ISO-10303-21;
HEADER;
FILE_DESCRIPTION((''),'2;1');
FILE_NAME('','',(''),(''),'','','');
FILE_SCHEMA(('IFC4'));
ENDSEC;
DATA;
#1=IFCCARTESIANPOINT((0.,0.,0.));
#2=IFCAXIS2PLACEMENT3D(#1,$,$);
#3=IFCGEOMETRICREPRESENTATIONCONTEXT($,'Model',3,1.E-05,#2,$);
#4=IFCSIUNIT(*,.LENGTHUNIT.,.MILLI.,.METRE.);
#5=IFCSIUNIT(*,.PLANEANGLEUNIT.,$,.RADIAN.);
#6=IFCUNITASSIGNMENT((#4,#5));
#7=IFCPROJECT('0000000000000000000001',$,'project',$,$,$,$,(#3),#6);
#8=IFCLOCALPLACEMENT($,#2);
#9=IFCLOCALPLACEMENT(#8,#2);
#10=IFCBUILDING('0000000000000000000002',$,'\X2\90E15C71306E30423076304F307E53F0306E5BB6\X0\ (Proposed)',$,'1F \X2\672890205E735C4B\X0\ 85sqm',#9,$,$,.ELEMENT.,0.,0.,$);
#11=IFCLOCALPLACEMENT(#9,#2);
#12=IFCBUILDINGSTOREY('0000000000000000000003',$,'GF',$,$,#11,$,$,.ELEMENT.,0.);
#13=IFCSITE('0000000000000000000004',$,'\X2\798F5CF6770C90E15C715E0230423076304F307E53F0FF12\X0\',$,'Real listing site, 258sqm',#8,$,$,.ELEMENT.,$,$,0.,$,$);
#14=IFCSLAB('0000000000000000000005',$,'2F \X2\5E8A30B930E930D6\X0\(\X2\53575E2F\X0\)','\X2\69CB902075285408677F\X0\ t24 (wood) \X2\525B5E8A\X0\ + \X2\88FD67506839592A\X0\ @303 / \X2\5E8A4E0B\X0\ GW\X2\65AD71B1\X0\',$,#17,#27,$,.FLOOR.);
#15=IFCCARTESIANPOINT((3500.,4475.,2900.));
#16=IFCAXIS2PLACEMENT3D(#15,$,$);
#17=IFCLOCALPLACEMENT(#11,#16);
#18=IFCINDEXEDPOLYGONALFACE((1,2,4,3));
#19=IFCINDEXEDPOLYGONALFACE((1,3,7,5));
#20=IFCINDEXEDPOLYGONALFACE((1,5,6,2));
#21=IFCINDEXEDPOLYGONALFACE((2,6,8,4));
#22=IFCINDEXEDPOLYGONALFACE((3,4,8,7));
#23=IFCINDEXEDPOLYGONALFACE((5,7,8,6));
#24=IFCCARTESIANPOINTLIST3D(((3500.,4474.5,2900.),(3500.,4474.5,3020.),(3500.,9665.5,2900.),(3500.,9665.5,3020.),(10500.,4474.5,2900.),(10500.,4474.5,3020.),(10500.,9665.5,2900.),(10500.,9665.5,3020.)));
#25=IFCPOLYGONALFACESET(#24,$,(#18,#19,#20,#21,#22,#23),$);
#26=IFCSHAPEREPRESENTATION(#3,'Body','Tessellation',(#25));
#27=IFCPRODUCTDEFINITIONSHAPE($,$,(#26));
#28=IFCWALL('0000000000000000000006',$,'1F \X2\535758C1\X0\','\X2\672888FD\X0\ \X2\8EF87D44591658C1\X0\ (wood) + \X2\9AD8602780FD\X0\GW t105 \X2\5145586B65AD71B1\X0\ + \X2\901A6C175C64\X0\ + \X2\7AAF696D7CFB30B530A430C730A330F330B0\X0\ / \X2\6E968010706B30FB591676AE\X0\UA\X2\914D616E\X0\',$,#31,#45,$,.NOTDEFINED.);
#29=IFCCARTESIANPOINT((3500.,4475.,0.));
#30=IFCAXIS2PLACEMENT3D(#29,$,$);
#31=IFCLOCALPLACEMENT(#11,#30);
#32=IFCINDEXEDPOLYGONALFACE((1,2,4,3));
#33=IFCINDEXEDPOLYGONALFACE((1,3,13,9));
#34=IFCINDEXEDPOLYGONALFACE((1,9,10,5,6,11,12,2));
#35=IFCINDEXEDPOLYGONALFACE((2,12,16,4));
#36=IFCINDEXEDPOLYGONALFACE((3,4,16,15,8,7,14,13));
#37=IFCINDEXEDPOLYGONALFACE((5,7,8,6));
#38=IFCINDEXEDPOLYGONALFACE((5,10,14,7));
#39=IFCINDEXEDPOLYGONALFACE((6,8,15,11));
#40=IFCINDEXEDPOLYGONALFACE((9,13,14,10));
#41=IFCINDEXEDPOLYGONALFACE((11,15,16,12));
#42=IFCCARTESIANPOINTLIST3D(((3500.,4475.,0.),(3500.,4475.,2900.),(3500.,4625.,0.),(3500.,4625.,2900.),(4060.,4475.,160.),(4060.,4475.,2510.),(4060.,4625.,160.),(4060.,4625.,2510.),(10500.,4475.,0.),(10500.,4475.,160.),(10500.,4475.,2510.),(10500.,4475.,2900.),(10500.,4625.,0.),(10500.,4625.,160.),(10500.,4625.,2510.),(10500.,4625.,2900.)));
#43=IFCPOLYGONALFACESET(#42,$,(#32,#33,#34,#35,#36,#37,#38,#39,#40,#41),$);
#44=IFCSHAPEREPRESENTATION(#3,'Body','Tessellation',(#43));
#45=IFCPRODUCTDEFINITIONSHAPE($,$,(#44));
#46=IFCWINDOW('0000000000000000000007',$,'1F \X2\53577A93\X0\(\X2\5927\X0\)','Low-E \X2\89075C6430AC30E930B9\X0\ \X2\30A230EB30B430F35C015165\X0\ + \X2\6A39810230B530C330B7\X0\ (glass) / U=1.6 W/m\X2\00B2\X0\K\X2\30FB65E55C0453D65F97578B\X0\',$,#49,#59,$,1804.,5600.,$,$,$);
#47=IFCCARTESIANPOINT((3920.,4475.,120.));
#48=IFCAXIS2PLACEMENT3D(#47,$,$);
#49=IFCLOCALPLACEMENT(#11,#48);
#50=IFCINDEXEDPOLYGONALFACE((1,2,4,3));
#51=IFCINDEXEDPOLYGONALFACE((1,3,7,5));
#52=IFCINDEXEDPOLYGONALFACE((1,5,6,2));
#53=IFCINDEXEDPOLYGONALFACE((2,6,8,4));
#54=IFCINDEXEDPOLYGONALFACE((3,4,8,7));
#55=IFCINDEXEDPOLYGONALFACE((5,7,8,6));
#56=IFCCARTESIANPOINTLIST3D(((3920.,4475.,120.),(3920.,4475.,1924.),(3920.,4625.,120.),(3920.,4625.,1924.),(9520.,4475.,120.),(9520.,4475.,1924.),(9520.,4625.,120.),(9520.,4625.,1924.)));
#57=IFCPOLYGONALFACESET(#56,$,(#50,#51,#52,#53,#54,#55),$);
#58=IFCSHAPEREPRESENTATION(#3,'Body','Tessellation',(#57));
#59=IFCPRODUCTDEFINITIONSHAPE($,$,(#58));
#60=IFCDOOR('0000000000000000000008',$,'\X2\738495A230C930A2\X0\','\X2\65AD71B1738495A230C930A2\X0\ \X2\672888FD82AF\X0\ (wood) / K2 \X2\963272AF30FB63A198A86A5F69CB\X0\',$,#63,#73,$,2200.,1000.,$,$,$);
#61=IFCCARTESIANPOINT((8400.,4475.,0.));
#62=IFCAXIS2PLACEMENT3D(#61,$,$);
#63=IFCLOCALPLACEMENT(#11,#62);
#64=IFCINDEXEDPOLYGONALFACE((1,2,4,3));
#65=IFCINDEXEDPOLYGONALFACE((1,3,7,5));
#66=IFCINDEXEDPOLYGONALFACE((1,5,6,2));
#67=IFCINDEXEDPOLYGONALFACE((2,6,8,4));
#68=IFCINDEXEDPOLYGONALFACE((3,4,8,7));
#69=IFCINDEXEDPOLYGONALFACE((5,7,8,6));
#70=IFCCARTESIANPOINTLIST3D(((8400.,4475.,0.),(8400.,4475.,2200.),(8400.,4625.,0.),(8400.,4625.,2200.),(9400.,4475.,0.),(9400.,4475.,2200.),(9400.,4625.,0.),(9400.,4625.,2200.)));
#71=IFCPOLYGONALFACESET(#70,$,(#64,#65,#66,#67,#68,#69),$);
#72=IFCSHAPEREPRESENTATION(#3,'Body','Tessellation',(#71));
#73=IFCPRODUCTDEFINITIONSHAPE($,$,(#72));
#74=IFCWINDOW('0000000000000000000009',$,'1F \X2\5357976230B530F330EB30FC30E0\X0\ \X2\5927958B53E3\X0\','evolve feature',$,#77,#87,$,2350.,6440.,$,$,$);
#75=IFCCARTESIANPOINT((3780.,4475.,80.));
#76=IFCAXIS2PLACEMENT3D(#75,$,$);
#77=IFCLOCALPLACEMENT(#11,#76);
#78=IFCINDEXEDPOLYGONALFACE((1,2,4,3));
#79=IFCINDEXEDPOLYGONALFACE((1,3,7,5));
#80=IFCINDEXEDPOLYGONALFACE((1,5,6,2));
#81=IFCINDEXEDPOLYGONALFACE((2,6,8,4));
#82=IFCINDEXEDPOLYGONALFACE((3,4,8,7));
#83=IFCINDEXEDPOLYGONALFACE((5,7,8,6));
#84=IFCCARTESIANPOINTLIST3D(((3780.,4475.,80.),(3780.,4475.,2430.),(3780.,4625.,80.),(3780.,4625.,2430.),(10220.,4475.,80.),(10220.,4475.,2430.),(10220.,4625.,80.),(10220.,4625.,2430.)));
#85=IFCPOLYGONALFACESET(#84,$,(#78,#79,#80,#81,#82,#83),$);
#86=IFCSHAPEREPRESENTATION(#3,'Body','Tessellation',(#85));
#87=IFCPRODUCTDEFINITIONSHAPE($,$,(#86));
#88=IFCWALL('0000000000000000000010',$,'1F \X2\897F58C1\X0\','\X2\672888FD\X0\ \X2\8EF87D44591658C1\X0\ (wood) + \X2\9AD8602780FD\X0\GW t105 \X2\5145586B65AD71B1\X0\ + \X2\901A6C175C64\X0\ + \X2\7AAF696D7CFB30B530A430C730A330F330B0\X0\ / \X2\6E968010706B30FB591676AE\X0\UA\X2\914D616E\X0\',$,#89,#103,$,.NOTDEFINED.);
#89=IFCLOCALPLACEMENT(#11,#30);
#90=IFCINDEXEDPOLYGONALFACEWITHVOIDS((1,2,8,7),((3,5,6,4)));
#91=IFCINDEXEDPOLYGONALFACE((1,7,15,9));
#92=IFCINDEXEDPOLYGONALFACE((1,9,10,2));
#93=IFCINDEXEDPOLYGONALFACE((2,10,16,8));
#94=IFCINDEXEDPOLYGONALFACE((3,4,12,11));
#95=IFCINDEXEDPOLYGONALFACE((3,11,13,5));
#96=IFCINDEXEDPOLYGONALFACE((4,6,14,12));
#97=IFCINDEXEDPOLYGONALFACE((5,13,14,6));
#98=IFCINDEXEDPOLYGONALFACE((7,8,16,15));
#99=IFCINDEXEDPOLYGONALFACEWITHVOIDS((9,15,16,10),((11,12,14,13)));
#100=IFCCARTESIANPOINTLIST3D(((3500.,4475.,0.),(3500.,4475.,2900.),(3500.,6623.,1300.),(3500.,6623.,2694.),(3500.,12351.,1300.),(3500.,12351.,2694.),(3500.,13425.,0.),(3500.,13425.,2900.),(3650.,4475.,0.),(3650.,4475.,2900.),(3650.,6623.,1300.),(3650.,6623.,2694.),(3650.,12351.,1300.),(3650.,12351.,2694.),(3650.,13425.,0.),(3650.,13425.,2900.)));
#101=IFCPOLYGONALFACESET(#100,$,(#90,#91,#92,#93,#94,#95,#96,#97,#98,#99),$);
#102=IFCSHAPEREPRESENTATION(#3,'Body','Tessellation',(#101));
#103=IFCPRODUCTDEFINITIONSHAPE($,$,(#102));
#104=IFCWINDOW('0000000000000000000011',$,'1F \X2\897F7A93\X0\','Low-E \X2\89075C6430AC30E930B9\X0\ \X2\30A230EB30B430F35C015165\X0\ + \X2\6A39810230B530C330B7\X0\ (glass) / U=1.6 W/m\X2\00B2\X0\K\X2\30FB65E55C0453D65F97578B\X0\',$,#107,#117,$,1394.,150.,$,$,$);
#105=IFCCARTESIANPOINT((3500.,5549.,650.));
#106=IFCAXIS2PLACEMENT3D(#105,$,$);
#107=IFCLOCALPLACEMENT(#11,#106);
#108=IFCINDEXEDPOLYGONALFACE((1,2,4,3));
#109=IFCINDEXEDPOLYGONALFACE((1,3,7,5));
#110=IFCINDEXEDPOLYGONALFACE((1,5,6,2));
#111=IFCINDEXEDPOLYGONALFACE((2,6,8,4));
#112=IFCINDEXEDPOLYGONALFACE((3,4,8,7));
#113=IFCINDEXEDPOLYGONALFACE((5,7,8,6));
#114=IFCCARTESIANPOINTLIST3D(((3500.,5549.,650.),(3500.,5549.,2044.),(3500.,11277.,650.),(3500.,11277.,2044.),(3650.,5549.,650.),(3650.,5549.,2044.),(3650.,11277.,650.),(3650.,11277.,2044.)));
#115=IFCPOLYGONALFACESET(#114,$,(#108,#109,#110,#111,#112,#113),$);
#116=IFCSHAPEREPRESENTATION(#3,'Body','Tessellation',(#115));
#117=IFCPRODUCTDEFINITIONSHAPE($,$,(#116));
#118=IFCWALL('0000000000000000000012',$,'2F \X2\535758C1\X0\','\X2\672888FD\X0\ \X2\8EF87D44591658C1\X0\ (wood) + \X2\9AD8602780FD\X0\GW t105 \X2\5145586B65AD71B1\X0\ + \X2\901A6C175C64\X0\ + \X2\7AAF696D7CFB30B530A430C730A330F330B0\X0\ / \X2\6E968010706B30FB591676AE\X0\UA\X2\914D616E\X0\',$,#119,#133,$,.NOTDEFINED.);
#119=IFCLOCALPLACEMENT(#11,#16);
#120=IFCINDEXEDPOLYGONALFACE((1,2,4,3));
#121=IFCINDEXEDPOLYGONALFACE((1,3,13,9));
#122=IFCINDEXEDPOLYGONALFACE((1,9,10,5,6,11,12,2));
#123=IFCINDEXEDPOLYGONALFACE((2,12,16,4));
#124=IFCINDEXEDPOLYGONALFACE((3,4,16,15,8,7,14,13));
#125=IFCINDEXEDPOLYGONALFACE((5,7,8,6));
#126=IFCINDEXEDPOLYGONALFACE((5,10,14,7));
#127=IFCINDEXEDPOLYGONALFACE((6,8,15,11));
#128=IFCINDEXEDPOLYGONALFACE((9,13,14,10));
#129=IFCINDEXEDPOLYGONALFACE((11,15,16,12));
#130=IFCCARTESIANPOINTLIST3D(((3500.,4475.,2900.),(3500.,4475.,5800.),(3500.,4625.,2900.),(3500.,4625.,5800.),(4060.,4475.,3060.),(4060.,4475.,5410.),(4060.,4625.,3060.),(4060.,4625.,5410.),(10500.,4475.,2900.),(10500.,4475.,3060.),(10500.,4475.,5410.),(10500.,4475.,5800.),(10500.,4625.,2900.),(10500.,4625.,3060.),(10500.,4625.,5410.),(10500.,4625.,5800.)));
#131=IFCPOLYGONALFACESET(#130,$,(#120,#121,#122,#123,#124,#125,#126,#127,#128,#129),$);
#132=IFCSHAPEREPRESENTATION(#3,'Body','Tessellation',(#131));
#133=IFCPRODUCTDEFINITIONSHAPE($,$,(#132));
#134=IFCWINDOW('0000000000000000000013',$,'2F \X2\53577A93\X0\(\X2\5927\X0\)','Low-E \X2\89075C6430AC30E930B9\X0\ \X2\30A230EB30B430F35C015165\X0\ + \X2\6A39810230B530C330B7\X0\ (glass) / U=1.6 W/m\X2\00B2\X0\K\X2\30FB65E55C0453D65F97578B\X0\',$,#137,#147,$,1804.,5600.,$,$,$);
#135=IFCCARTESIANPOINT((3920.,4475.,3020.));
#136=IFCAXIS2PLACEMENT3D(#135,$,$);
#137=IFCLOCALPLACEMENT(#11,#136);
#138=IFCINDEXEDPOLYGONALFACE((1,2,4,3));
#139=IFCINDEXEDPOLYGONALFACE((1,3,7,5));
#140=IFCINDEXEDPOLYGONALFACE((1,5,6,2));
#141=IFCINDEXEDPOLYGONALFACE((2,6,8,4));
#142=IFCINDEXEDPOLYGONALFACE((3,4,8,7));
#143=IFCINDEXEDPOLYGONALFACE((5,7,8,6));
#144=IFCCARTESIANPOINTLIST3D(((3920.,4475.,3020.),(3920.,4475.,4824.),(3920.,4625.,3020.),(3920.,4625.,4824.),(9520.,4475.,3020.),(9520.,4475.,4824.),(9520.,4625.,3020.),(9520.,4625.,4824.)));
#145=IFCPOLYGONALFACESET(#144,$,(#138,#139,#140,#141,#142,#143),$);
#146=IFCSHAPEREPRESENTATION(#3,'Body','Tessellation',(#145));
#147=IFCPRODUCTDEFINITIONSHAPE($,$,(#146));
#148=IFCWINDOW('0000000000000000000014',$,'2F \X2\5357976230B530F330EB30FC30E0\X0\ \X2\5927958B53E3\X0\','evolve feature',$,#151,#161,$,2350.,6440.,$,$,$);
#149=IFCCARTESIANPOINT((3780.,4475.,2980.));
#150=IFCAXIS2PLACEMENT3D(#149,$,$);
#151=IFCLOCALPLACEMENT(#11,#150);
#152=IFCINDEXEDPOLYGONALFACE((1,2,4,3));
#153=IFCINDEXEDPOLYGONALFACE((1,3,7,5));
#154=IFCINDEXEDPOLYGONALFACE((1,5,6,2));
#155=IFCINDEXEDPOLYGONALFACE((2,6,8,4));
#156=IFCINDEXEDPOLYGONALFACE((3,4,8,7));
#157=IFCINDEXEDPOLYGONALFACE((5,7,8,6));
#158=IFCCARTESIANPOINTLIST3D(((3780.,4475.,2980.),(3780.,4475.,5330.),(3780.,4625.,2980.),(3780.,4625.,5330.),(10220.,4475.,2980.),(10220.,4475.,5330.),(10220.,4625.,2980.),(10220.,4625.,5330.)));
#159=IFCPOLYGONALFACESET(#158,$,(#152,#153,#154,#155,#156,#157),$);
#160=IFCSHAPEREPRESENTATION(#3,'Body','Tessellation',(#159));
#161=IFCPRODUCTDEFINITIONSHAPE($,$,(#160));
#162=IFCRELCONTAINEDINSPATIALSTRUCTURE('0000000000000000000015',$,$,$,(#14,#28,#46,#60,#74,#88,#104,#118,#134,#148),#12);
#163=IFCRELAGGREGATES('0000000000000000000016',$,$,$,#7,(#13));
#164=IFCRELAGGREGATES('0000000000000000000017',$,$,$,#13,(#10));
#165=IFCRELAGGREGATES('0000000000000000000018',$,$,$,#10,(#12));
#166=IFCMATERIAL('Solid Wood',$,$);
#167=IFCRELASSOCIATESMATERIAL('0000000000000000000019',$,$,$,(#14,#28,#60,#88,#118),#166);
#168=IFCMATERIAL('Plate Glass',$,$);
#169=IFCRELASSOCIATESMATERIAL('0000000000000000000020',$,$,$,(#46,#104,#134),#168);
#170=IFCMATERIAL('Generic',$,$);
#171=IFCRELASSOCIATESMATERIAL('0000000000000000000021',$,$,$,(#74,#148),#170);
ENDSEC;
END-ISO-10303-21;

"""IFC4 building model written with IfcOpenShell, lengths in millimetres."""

from ifc_helpers import new_model, si_unit, frame, frame_2d, origin, place, context, project, spatial, rectangle, extrude, material, element, fill, save


model = new_model("IFC4")

# Units and contexts
model_context = context("Model", 3, precision=1e-05, world=origin())
ifc_project = project(units=[si_unit("LENGTHUNIT", "METRE", prefix="MILLI"), si_unit("PLANEANGLEUNIT", "RADIAN")], contexts=[model_context])

# Site, building, storey
site_placement = place(None, origin())
site = spatial("IfcSite", under=ifc_project, at=site_placement, Name="福島県郡山市あぶくま台２", ObjectType="Real listing site, 258sqm", CompositionType="ELEMENT", RefElevation=0.0)
building_placement = place(site_placement, origin())
building = spatial("IfcBuilding", under=site, at=building_placement, Name="郡山のあぶくま台の家 (Proposed)", ObjectType="1F 木造平屋 85sqm", CompositionType="ELEMENT", ElevationOfRefHeight=0.0, ElevationOfTerrain=0.0)
storey_placement = place(building_placement, origin())
storey = spatial("IfcBuildingStorey", under=building, at=storey_placement, Name="GF", CompositionType="ELEMENT", Elevation=0.0)

# Slab
ifc_material_1 = material(Name="Solid Wood")
slab_1_placement = place(storey_placement, frame((3500.0, 4475.0, 2900.0)))
element("IfcSlab", 1, at=slab_1_placement, inside=storey, material=ifc_material_1, Name="2F 床スラブ(南帯)", Description="構造用合板 t24 (wood) 剛床 + 製材根太 @303 / 床下 GW断熱", PredefinedType="FLOOR", context=model_context, shape_type="SweptSolid", body=[
    extrude(rectangle(XDim=7000.0, YDim=5191.0, at=frame_2d((3500.0, 2595.0))), frame((3500.0, 4475.0, 2900.0)), (0.0, 0.0, 1.0), 120.0),
])
ifc_material_2 = material(Name="Generic")

# Wall, openings, windows, door
wall_1_placement = place(storey_placement, frame((3500.0, 4475.0, 0.0)))
wall_1 = element("IfcWall", 2, at=wall_1_placement, inside=storey, material=ifc_material_1, Name="1F 南壁", Description="木製 軸組外壁 (wood) + 高性能GW t105 充填断熱 + 通気層 + 窯業系サイディング / 準耐火・外皮UA配慮", PredefinedType="NOTDEFINED", context=model_context, shape_type="SweptSolid", body=[
    extrude(rectangle(XDim=7000.0, YDim=150.0, at=frame_2d((3500.0, 75.0))), frame((3500.0, 4475.0, 0.0)), (0.0, 0.0, 1.0), 2900.0),
])
opening_1_placement = place(storey_placement, frame((3920.0, 4475.0, 120.0)))
opening_1 = element("IfcOpeningElement", 3, at=opening_1_placement, cuts=wall_1, PredefinedType="NOTDEFINED", context=model_context, shape_type="SweptSolid", body=[
    extrude(rectangle(XDim=5600.0, YDim=150.0, at=frame_2d((2800.0, 75.0))), frame((3920.0, 4475.0, 120.0)), (0.0, 0.0, 1.0), 1804.0),
])
opening_2_placement = place(storey_placement, frame((8400.0, 4475.0, 0.0)))
opening_2 = element("IfcOpeningElement", 4, at=opening_2_placement, cuts=wall_1, PredefinedType="NOTDEFINED", context=model_context, shape_type="SweptSolid", body=[
    extrude(rectangle(XDim=1000.0, YDim=150.0, at=frame_2d((500.0, 75.0))), frame((8400.0, 4475.0, 0.0)), (0.0, 0.0, 1.0), 2200.0),
])
opening_3_placement = place(storey_placement, frame((3780.0, 4475.0, 80.0)))
opening_3 = element("IfcOpeningElement", 5, at=opening_3_placement, cuts=wall_1, PredefinedType="NOTDEFINED", context=model_context, shape_type="SweptSolid", body=[
    extrude(rectangle(XDim=6440.0, YDim=150.0, at=frame_2d((3220.0, 75.0))), frame((3780.0, 4475.0, 80.0)), (0.0, 0.0, 1.0), 2350.0),
])
ifc_material_3 = material(Name="Plate Glass")
window_1_placement = place(storey_placement, frame((3920.0, 4475.0, 120.0)))
window_1 = element("IfcWindow", 6, at=window_1_placement, inside=storey, material=ifc_material_3, Name="1F 南窓(大)", Description="Low-E 複層ガラス アルゴン封入 + 樹脂サッシ (glass) / U=1.6 W/m²K・日射取得型", OverallHeight=1804.0, OverallWidth=5600.0, context=model_context, shape_type="SweptSolid", body=[
    extrude(rectangle(XDim=5600.0, YDim=150.0, at=frame_2d((2800.0, 75.0))), frame((3920.0, 4475.0, 120.0)), (0.0, 0.0, 1.0), 1804.0),
])
fill(opening_1, window_1)
door_placement = place(storey_placement, frame((8400.0, 4475.0, 0.0)))
door = element("IfcDoor", 7, at=door_placement, inside=storey, material=ifc_material_1, Name="玄関ドア", Description="断熱玄関ドア 木製芯 (wood) / K2 防犯・採風機構", OverallHeight=2200.0, OverallWidth=1000.0, context=model_context, shape_type="SweptSolid", body=[
    extrude(rectangle(XDim=1000.0, YDim=150.0, at=frame_2d((500.0, 75.0))), frame((8400.0, 4475.0, 0.0)), (0.0, 0.0, 1.0), 2200.0),
])
fill(opening_2, door)
window_2_placement = place(storey_placement, frame((3780.0, 4475.0, 80.0)))
window_2 = element("IfcWindow", 8, at=window_2_placement, inside=storey, material=ifc_material_2, Name="1F 南面サンルーム 大開口", Description="evolve feature", OverallHeight=2350.0, OverallWidth=6440.0, context=model_context, shape_type="SweptSolid", body=[
    extrude(rectangle(XDim=6440.0, YDim=150.0, at=frame_2d((3220.0, 75.0))), frame((3780.0, 4475.0, 80.0)), (0.0, 0.0, 1.0), 2350.0),
])
fill(opening_3, window_2)

# Wall, opening, window
wall_2_placement = place(storey_placement, frame((3500.0, 4475.0, 0.0)))
wall_2 = element("IfcWall", 9, at=wall_2_placement, inside=storey, material=ifc_material_1, Name="1F 西壁", Description="木製 軸組外壁 (wood) + 高性能GW t105 充填断熱 + 通気層 + 窯業系サイディング / 準耐火・外皮UA配慮", PredefinedType="NOTDEFINED", context=model_context, shape_type="SweptSolid", body=[
    extrude(rectangle(XDim=150.0, YDim=8950.0, at=frame_2d((75.0, 4475.0))), frame((3500.0, 4475.0, 0.0)), (0.0, 0.0, 1.0), 2900.0),
])
opening_4_placement = place(storey_placement, frame((3500.0, 5549.0, 650.0)))
opening_4 = element("IfcOpeningElement", 10, at=opening_4_placement, cuts=wall_2, PredefinedType="NOTDEFINED", context=model_context, shape_type="SweptSolid", body=[
    extrude(rectangle(XDim=150.0, YDim=5728.0, at=frame_2d((75.0, 2864.0))), frame((3500.0, 5549.0, 650.0)), (0.0, 0.0, 1.0), 1394.0),
])
window_3_placement = place(storey_placement, frame((3500.0, 5549.0, 650.0)))
window_3 = element("IfcWindow", 11, at=window_3_placement, inside=storey, material=ifc_material_3, Name="1F 西窓", Description="Low-E 複層ガラス アルゴン封入 + 樹脂サッシ (glass) / U=1.6 W/m²K・日射取得型", OverallHeight=1394.0, OverallWidth=150.0, context=model_context, shape_type="SweptSolid", body=[
    extrude(rectangle(XDim=150.0, YDim=5728.0, at=frame_2d((75.0, 2864.0))), frame((3500.0, 5549.0, 650.0)), (0.0, 0.0, 1.0), 1394.0),
])
fill(opening_4, window_3)

# Wall, openings, windows
wall_3_placement = place(storey_placement, frame((3500.0, 4475.0, 2900.0)))
wall_3 = element("IfcWall", 12, at=wall_3_placement, inside=storey, material=ifc_material_1, Name="2F 南壁", Description="木製 軸組外壁 (wood) + 高性能GW t105 充填断熱 + 通気層 + 窯業系サイディング / 準耐火・外皮UA配慮", PredefinedType="NOTDEFINED", context=model_context, shape_type="SweptSolid", body=[
    extrude(rectangle(XDim=7000.0, YDim=150.0, at=frame_2d((3500.0, 75.0))), frame((3500.0, 4475.0, 2900.0)), (0.0, 0.0, 1.0), 2900.0),
])
opening_5_placement = place(storey_placement, frame((3920.0, 4475.0, 3020.0)))
opening_5 = element("IfcOpeningElement", 13, at=opening_5_placement, cuts=wall_3, PredefinedType="NOTDEFINED", context=model_context, shape_type="SweptSolid", body=[
    extrude(rectangle(XDim=5600.0, YDim=150.0, at=frame_2d((2800.0, 75.0))), frame((3920.0, 4475.0, 3020.0)), (0.0, 0.0, 1.0), 1804.0),
])
opening_6_placement = place(storey_placement, frame((3780.0, 4475.0, 2980.0)))
opening_6 = element("IfcOpeningElement", 14, at=opening_6_placement, cuts=wall_3, PredefinedType="NOTDEFINED", context=model_context, shape_type="SweptSolid", body=[
    extrude(rectangle(XDim=6440.0, YDim=150.0, at=frame_2d((3220.0, 75.0))), frame((3780.0, 4475.0, 2980.0)), (0.0, 0.0, 1.0), 2350.0),
])
window_4_placement = place(storey_placement, frame((3920.0, 4475.0, 3020.0)))
window_4 = element("IfcWindow", 15, at=window_4_placement, inside=storey, material=ifc_material_3, Name="2F 南窓(大)", Description="Low-E 複層ガラス アルゴン封入 + 樹脂サッシ (glass) / U=1.6 W/m²K・日射取得型", OverallHeight=1804.0, OverallWidth=5600.0, context=model_context, shape_type="SweptSolid", body=[
    extrude(rectangle(XDim=5600.0, YDim=150.0, at=frame_2d((2800.0, 75.0))), frame((3920.0, 4475.0, 3020.0)), (0.0, 0.0, 1.0), 1804.0),
])
fill(opening_5, window_4)
window_5_placement = place(storey_placement, frame((3780.0, 4475.0, 2980.0)))
window_5 = element("IfcWindow", 16, at=window_5_placement, inside=storey, material=ifc_material_2, Name="2F 南面サンルーム 大開口", Description="evolve feature", OverallHeight=2350.0, OverallWidth=6440.0, context=model_context, shape_type="SweptSolid", body=[
    extrude(rectangle(XDim=6440.0, YDim=150.0, at=frame_2d((3220.0, 75.0))), frame((3780.0, 4475.0, 2980.0)), (0.0, 0.0, 1.0), 2350.0),
])
fill(opening_6, window_5)

save(model, "model.ifc")
